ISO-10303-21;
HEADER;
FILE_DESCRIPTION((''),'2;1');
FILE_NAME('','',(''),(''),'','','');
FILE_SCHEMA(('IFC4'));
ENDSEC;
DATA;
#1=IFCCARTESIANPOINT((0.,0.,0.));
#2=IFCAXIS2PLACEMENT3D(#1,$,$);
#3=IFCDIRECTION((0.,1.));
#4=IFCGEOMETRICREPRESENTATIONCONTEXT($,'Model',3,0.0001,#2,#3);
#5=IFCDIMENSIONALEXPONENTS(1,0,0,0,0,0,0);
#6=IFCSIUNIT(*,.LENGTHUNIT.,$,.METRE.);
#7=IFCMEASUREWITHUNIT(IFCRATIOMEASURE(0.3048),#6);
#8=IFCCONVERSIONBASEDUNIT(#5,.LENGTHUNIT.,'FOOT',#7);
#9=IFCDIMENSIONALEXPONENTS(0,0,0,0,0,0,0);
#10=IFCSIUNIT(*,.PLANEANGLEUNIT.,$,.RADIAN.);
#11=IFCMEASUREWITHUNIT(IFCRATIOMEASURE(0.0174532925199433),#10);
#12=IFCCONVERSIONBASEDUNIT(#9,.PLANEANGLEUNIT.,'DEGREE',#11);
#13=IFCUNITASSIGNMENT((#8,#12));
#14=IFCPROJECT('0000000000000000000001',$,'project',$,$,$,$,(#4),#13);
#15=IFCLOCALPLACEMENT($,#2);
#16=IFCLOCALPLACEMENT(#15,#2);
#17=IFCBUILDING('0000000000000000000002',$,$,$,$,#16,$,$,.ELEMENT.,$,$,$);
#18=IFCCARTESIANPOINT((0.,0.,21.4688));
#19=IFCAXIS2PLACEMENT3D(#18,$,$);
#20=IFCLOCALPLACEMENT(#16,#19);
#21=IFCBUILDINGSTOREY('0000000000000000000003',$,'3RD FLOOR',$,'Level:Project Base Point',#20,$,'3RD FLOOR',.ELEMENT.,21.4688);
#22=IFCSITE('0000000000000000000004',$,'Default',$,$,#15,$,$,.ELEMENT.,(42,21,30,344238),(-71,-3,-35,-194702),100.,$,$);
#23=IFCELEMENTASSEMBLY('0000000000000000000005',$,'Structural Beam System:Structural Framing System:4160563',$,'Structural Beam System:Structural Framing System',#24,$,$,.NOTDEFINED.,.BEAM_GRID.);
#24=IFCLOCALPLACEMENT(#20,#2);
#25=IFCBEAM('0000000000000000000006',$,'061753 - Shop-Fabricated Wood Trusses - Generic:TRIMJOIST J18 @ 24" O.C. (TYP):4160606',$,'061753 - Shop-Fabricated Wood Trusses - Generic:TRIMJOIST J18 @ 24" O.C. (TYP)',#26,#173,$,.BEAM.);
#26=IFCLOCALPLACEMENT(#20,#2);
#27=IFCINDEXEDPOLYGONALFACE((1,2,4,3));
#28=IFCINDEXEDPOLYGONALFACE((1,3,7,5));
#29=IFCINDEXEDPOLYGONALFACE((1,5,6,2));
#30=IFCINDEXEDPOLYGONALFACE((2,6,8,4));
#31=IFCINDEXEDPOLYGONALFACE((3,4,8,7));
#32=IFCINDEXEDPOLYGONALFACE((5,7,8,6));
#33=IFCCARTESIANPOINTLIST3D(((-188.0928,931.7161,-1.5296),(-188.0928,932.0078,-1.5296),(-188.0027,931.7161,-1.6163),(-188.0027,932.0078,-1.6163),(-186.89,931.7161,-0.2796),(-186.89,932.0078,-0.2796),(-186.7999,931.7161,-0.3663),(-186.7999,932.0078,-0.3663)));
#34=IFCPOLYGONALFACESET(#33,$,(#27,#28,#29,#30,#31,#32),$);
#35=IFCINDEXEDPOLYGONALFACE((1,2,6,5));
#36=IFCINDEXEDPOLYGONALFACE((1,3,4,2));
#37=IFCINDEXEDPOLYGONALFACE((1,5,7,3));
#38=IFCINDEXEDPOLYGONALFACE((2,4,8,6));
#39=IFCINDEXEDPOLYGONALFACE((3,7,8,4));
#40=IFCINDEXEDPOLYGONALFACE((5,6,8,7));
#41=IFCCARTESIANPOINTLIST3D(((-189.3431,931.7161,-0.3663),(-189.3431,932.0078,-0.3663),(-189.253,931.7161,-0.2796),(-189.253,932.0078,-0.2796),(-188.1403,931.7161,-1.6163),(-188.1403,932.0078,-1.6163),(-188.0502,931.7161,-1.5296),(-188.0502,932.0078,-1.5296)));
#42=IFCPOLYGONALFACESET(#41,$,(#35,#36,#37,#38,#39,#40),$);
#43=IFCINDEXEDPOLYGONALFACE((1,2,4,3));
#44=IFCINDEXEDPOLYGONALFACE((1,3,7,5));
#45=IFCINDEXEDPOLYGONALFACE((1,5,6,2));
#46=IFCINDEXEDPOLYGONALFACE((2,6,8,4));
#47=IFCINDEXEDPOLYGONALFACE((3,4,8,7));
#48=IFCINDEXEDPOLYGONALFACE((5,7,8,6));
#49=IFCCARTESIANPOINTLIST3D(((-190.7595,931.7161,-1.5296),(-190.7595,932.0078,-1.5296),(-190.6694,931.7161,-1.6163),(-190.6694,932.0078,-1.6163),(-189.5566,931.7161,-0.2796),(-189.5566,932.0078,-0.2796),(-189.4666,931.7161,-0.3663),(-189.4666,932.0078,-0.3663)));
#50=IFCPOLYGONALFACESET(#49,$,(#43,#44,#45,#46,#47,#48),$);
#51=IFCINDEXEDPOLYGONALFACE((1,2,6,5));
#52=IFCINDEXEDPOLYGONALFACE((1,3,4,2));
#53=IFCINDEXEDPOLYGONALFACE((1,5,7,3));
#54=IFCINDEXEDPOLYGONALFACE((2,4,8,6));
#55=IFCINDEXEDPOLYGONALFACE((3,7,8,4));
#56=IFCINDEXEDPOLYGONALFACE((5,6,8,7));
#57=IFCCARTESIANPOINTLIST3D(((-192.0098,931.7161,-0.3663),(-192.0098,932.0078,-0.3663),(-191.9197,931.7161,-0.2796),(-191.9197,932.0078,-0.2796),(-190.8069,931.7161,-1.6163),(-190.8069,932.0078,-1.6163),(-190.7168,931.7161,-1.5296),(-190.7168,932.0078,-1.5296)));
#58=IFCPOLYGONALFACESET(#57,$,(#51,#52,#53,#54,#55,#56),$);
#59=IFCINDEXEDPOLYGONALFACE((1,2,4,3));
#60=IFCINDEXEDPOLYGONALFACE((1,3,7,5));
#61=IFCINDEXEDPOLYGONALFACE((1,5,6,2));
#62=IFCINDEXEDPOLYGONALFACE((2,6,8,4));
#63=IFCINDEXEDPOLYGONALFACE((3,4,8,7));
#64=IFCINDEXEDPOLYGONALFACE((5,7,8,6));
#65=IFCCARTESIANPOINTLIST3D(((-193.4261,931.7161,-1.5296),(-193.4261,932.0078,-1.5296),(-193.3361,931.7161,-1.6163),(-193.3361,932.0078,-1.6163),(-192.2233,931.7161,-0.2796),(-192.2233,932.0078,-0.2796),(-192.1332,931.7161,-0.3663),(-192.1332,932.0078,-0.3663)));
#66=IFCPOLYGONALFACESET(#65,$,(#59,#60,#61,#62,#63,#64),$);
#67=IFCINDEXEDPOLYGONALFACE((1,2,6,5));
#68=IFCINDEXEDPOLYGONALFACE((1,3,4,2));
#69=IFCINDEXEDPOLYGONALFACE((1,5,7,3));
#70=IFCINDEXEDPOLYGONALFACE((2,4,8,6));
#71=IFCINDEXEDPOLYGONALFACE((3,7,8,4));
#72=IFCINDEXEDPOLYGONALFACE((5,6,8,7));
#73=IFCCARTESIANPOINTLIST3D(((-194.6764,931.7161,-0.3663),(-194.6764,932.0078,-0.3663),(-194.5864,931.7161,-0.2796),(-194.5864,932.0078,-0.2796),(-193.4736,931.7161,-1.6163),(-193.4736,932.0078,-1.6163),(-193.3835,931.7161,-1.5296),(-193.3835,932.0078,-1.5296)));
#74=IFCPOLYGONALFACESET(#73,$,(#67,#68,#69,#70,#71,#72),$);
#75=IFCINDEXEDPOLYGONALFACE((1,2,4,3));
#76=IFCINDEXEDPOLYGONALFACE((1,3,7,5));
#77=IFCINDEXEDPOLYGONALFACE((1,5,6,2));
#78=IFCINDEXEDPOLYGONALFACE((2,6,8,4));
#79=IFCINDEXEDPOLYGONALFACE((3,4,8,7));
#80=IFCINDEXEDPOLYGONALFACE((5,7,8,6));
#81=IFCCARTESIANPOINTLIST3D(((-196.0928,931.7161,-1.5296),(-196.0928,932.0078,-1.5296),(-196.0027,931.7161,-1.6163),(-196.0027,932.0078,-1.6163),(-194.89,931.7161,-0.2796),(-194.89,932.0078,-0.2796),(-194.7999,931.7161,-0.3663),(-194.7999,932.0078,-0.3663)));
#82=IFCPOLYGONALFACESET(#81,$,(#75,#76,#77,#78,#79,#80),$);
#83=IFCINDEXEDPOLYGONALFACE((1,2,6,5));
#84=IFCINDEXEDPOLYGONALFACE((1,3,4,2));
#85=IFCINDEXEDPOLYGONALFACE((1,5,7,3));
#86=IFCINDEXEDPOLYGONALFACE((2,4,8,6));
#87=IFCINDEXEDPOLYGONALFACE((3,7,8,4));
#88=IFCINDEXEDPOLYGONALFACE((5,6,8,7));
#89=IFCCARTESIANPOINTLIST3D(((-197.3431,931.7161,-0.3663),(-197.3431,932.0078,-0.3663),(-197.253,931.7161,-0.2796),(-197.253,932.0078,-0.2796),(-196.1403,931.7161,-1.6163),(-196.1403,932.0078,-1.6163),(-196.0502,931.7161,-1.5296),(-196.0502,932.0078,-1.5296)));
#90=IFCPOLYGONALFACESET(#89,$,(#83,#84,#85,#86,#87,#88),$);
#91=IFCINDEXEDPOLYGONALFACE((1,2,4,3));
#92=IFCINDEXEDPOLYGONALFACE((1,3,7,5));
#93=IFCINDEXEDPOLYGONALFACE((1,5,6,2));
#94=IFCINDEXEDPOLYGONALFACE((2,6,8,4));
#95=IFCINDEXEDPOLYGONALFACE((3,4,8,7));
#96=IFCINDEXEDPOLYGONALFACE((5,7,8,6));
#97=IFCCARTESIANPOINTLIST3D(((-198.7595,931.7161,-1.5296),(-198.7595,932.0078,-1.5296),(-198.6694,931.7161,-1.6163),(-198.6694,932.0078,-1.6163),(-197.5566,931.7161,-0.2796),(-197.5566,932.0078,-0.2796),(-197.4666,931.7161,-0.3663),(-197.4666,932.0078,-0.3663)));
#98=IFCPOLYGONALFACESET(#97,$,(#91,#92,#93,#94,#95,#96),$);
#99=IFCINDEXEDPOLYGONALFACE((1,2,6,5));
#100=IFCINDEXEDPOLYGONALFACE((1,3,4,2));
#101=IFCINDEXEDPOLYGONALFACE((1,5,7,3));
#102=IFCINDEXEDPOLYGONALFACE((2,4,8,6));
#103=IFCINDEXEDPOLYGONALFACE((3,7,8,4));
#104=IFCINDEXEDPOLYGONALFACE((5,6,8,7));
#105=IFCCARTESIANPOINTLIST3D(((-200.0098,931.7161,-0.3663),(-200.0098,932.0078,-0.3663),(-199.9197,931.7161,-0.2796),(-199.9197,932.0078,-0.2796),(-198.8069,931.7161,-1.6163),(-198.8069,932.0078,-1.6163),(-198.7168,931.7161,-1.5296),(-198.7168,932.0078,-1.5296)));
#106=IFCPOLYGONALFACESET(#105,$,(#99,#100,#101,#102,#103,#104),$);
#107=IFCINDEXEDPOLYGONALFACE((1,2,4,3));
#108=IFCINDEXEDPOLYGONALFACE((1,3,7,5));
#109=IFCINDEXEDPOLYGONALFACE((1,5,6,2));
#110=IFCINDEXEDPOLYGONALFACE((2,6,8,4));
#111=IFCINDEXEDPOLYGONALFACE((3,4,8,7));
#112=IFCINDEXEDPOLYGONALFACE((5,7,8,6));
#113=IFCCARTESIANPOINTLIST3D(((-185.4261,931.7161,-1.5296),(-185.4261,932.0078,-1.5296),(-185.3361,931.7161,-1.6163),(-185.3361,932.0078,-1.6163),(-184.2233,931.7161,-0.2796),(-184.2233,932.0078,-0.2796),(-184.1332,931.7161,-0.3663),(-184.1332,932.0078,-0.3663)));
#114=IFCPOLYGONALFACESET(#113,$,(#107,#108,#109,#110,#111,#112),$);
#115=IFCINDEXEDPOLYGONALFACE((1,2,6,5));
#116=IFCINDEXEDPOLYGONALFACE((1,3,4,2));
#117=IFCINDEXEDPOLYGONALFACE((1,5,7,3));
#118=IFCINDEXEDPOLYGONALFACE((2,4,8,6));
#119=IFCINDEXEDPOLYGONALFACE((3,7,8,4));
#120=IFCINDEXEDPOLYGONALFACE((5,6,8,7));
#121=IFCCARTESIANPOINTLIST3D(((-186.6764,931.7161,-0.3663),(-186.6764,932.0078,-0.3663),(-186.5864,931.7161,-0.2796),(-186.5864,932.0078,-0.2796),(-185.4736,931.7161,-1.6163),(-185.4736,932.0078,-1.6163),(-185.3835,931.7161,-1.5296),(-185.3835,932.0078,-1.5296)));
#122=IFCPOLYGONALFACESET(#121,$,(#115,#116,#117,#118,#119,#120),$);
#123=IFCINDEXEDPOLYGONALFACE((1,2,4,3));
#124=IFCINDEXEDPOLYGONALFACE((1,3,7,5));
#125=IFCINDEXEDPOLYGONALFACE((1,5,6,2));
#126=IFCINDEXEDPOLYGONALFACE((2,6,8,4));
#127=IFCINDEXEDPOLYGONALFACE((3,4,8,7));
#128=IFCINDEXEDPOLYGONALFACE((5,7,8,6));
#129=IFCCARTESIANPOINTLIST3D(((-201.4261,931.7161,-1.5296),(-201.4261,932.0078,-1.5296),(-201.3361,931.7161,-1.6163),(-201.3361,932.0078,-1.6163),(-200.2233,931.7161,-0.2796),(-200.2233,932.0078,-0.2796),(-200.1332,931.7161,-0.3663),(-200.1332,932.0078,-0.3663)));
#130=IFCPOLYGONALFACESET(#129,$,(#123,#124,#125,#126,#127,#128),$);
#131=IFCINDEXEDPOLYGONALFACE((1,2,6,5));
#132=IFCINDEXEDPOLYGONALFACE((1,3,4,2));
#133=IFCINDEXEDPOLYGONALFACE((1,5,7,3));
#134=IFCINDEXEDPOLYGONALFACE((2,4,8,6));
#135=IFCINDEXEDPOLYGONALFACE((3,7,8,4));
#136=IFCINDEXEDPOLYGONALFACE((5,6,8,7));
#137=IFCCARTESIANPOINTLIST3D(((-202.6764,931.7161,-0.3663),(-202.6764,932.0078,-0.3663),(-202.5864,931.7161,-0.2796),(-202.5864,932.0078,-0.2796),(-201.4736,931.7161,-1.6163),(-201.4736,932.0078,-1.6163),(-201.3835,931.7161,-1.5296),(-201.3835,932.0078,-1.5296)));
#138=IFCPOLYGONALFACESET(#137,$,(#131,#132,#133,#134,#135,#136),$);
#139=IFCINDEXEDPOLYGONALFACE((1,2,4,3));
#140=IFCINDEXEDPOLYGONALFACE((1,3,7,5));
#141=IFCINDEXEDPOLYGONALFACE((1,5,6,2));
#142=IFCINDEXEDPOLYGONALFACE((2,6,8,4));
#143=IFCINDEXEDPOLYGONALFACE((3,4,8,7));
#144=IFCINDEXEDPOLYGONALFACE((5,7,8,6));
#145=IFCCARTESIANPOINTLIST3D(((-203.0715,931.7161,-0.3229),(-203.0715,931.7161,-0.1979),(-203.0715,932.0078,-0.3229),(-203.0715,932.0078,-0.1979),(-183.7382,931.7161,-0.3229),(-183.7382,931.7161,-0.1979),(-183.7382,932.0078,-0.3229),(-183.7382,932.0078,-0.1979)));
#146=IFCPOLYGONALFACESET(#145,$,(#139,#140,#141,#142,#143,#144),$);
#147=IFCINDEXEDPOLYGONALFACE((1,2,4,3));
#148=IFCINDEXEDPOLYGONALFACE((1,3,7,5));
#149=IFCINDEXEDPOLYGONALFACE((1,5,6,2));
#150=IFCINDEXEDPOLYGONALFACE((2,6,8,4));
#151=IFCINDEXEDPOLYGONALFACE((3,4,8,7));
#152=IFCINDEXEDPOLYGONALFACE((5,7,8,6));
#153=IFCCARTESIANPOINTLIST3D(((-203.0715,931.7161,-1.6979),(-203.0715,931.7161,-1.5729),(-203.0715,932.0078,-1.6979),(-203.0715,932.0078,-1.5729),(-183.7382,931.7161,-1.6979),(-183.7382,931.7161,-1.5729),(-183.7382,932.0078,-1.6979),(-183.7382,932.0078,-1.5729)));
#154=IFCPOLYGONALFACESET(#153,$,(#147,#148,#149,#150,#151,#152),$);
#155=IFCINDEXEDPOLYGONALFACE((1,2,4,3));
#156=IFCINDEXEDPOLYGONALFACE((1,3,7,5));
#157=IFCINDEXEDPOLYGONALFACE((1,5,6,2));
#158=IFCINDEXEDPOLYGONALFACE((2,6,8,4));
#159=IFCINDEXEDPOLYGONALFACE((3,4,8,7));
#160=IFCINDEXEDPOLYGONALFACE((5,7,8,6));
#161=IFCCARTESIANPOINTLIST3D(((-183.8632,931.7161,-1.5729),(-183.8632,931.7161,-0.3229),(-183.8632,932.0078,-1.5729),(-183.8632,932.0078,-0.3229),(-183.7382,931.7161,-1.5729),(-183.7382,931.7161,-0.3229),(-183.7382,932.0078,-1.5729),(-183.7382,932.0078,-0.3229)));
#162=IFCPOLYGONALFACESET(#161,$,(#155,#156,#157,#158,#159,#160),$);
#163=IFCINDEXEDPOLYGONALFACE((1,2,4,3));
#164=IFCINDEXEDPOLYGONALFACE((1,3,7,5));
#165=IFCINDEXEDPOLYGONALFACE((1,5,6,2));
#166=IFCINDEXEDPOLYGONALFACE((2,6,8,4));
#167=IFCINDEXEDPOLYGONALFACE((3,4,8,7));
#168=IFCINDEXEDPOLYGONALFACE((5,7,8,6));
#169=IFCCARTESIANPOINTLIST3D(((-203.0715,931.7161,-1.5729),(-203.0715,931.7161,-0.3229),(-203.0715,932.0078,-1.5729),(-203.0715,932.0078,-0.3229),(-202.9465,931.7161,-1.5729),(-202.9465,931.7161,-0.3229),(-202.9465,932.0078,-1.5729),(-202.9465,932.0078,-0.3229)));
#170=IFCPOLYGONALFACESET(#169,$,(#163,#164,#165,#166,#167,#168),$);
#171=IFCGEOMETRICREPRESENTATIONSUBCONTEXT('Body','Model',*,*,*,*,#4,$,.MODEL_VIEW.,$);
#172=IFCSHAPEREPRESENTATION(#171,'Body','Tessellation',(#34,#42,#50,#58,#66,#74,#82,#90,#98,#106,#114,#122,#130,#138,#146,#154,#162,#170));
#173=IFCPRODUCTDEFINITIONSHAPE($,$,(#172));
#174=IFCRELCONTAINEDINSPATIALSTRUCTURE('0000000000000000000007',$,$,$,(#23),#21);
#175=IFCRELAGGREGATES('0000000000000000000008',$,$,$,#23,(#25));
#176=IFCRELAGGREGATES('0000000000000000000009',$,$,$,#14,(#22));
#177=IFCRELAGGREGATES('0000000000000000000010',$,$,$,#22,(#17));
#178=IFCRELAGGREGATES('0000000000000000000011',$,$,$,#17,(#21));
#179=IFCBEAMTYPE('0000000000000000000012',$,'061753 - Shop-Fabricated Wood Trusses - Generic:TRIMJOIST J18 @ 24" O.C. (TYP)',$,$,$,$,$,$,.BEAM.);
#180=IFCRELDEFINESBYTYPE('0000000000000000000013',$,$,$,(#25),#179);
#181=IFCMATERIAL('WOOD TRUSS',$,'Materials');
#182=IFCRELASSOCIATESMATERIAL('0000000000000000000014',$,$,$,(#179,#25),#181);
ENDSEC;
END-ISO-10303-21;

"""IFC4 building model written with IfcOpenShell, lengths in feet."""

from ifc_helpers import new_model, entity, si_unit, converted_unit, direction, frame, frame_2d, origin, origin_2d_with_axis, place, context, subcontext, project, spatial, rectangle, extrude, source, transform, mapped, material, material_profile, profile_set, profile_usage, type_object, type_shapes, element, aggregate, save


model = new_model("IFC4")

# Units and contexts
model_context = context("Model", 3, precision=0.0001, world=origin(), true_north=direction((0.0, 1.0)))
body_context = subcontext(model_context, "Body", "Model", "MODEL_VIEW")
ifc_project = project(units=[converted_unit("LENGTHUNIT", "FOOT", entity("IfcRatioMeasure", 0.3048), si_unit("LENGTHUNIT", "METRE"), dimensions=[1, 0, 0, 0, 0, 0, 0]), converted_unit("PLANEANGLEUNIT", "DEGREE", entity("IfcRatioMeasure", 0.0174532925199433), si_unit("PLANEANGLEUNIT", "RADIAN"), dimensions=[0, 0, 0, 0, 0, 0, 0])], contexts=[model_context])

# Site, building, storey
site_placement = place(None, origin())
site = spatial("IfcSite", under=ifc_project, at=site_placement, Name="Default", CompositionType="ELEMENT", RefLatitude=(42, 21, 30, 344238), RefLongitude=(-71, -3, -35, -194702), RefElevation=100.0)
building_placement = place(site_placement, origin())
building = spatial("IfcBuilding", under=site, at=building_placement, CompositionType="ELEMENT")
storey_placement = place(building_placement, frame((0.0, 0.0, 21.4688)))
storey = spatial("IfcBuildingStorey", under=building, at=storey_placement, Name="3RD FLOOR", ObjectType="Level:Project Base Point", LongName="3RD FLOOR", CompositionType="ELEMENT", Elevation=21.4688)

# Element assembly, beam
ifc_material = material(Name="WOOD TRUSS", Category="Materials")
ifc_material_profile_1 = material_profile(ifc_material, rectangle(XDim=1.7347, YDim=0.125, at=frame_2d((0.0, 0.0), x_axis=(1.0, 0.0))), Name="TRIMJOIST J18 @ 24\" O.C. (TYP)")
ifc_material_profile_2 = material_profile(ifc_material, rectangle(XDim=1.7347, YDim=0.125, at=frame_2d((0.0, 0.0), x_axis=(1.0, 0.0))), Name="TRIMJOIST J18 @ 24\" O.C. (TYP)")
ifc_material_profile_3 = material_profile(ifc_material, rectangle(XDim=1.7347, YDim=0.125, at=frame_2d((0.0, 0.0), x_axis=(1.0, 0.0))), Name="TRIMJOIST J18 @ 24\" O.C. (TYP)")
ifc_material_profile_4 = material_profile(ifc_material, rectangle(XDim=1.7347, YDim=0.125, at=frame_2d((0.0, 0.0), x_axis=(1.0, 0.0))), Name="TRIMJOIST J18 @ 24\" O.C. (TYP)")
ifc_material_profile_5 = material_profile(ifc_material, rectangle(XDim=1.7347, YDim=0.125, at=frame_2d((0.0, 0.0), x_axis=(1.0, 0.0))), Name="TRIMJOIST J18 @ 24\" O.C. (TYP)")
ifc_material_profile_6 = material_profile(ifc_material, rectangle(XDim=1.7347, YDim=0.125, at=frame_2d((0.0, 0.0), x_axis=(1.0, 0.0))), Name="TRIMJOIST J18 @ 24\" O.C. (TYP)")
ifc_material_profile_7 = material_profile(ifc_material, rectangle(XDim=1.7347, YDim=0.125, at=frame_2d((0.0, 0.0), x_axis=(1.0, 0.0))), Name="TRIMJOIST J18 @ 24\" O.C. (TYP)")
ifc_material_profile_8 = material_profile(ifc_material, rectangle(XDim=1.7347, YDim=0.125, at=frame_2d((0.0, 0.0), x_axis=(1.0, 0.0))), Name="TRIMJOIST J18 @ 24\" O.C. (TYP)")
ifc_material_profile_9 = material_profile(ifc_material, rectangle(XDim=1.7347, YDim=0.125, at=frame_2d((0.0, 0.0), x_axis=(1.0, 0.0))), Name="TRIMJOIST J18 @ 24\" O.C. (TYP)")
ifc_material_profile_10 = material_profile(ifc_material, rectangle(XDim=1.7347, YDim=0.125, at=origin_2d_with_axis()), Name="TRIMJOIST J18 @ 24\" O.C. (TYP)")
ifc_material_profile_11 = material_profile(ifc_material, rectangle(XDim=0.125, YDim=0.2917, at=origin_2d_with_axis()), Name="TRIMJOIST J18 @ 24\" O.C. (TYP)")
ifc_material_profile_12 = material_profile(ifc_material, rectangle(XDim=0.125, YDim=0.2917, at=origin_2d_with_axis()), Name="TRIMJOIST J18 @ 24\" O.C. (TYP)")
ifc_material_profile_13 = material_profile(ifc_material, rectangle(XDim=1.25, YDim=0.2917, at=origin_2d_with_axis()), Name="TRIMJOIST J18 @ 24\" O.C. (TYP)")
ifc_material_profile_14 = material_profile(ifc_material, rectangle(XDim=1.25, YDim=0.2917, at=origin_2d_with_axis()), Name="TRIMJOIST J18 @ 24\" O.C. (TYP)")
ifc_profile_set = profile_set([ifc_material_profile_1, ifc_material_profile_2, ifc_material_profile_3, ifc_material_profile_4, ifc_material_profile_5, ifc_material_profile_6, ifc_material_profile_7, ifc_material_profile_8, ifc_material_profile_9, ifc_material_profile_10, ifc_material_profile_11, ifc_material_profile_12, ifc_material_profile_13, ifc_material_profile_14], Name="TRIMJOIST J18 @ 24\" O.C. (TYP)")
beam_type_1 = type_object("IfcBeamType", Name="061753 - Shop-Fabricated Wood Trusses - Generic:TRIMJOIST J18 @ 24\" O.C. (TYP)", PredefinedType="BEAM", material=ifc_profile_set)
shared_shape_1 = source(origin(), body_context, "Body", "SweptSolid", [
    extrude(rectangle(XDim=1.7347, YDim=0.125, at=frame_2d((0.0, 0.0), x_axis=(1.0, 0.0))), frame((5.9585, -0.1458, 0.0), z_axis=(0.0, 1.0, 0.0), x_axis=(0.693383, 0.0, 0.720569)), (0.0, 0.0, 1.0), 0.2917),
    extrude(rectangle(XDim=1.7347, YDim=0.125, at=origin_2d_with_axis()), frame((4.7082, -0.1458, 0.0), z_axis=(0.0, 1.0, 0.0), x_axis=(0.693383, 0.0, -0.720569)), (0.0, 0.0, 1.0), 0.2917),
    extrude(rectangle(XDim=1.7347, YDim=0.125, at=frame_2d((0.0, 0.0), x_axis=(1.0, 0.0))), frame((3.2918, -0.1458, 0.0), z_axis=(0.0, 1.0, 0.0), x_axis=(0.693383, 0.0, 0.720569)), (0.0, 0.0, 1.0), 0.2917),
    extrude(rectangle(XDim=1.7347, YDim=0.125, at=frame_2d((0.0, 0.0), x_axis=(1.0, 0.0))), frame((2.0415, -0.1458, 0.0), z_axis=(0.0, 1.0, 0.0), x_axis=(0.693383, 0.0, -0.720569)), (0.0, 0.0, 1.0), 0.2917),
    extrude(rectangle(XDim=1.7347, YDim=0.125, at=frame_2d((0.0, 0.0), x_axis=(1.0, 0.0))), frame((0.6251, -0.1458, 0.0), z_axis=(0.0, 1.0, 0.0), x_axis=(0.693383, 0.0, 0.720569)), (0.0, 0.0, 1.0), 0.2917),
    extrude(rectangle(XDim=1.7347, YDim=0.125, at=frame_2d((0.0, 0.0), x_axis=(1.0, 0.0))), frame((-0.6251, -0.1458, 0.0), z_axis=(0.0, 1.0, 0.0), x_axis=(0.693383, 0.0, -0.720569)), (0.0, 0.0, 1.0), 0.2917),
    extrude(rectangle(XDim=1.7347, YDim=0.125, at=frame_2d((0.0, 0.0), x_axis=(1.0, 0.0))), frame((-2.0415, -0.1458, 0.0), z_axis=(0.0, 1.0, 0.0), x_axis=(0.693383, 0.0, 0.720569)), (0.0, 0.0, 1.0), 0.2917),
    extrude(rectangle(XDim=1.7347, YDim=0.125, at=origin_2d_with_axis()), frame((-3.2918, -0.1458, 0.0), z_axis=(0.0, 1.0, 0.0), x_axis=(0.693383, 0.0, -0.720569)), (0.0, 0.0, 1.0), 0.2917),
    extrude(rectangle(XDim=1.7347, YDim=0.125, at=frame_2d((0.0, 0.0), x_axis=(1.0, 0.0))), frame((-4.7082, -0.1458, 0.0), z_axis=(0.0, 1.0, 0.0), x_axis=(0.693383, 0.0, 0.720569)), (0.0, 0.0, 1.0), 0.2917),
    extrude(rectangle(XDim=1.7347, YDim=0.125, at=frame_2d((0.0, 0.0), x_axis=(1.0, 0.0))), frame((-5.9585, -0.1458, 0.0), z_axis=(0.0, 1.0, 0.0), x_axis=(0.693383, 0.0, -0.720569)), (0.0, 0.0, 1.0), 0.2917),
    extrude(rectangle(XDim=1.7347, YDim=0.125, at=frame_2d((0.0, 0.0), x_axis=(1.0, 0.0))), frame((8.6251, -0.1458, 0.0), z_axis=(0.0, 1.0, 0.0), x_axis=(0.693383, 0.0, 0.720569)), (0.0, 0.0, 1.0), 0.2917),
    extrude(rectangle(XDim=1.7347, YDim=0.125, at=origin_2d_with_axis()), frame((7.3749, -0.1458, 0.0), z_axis=(0.0, 1.0, 0.0), x_axis=(0.693383, 0.0, -0.720569)), (0.0, 0.0, 1.0), 0.2917),
    extrude(rectangle(XDim=1.7347, YDim=0.125, at=frame_2d((0.0, 0.0), x_axis=(1.0, 0.0))), frame((-7.3749, -0.1458, 0.0), z_axis=(0.0, 1.0, 0.0), x_axis=(0.693383, 0.0, 0.720569)), (0.0, 0.0, 1.0), 0.2917),
    extrude(rectangle(XDim=1.7347, YDim=0.125, at=origin_2d_with_axis()), frame((-8.6251, -0.1458, 0.0), z_axis=(0.0, 1.0, 0.0), x_axis=(0.693383, 0.0, -0.720569)), (0.0, 0.0, 1.0), 0.2917),
    extrude(rectangle(XDim=0.125, YDim=0.2917, at=origin_2d_with_axis()), frame((-9.6667, 0.0, 0.6875), z_axis=(1.0, 0.0, 0.0), x_axis=(0.0, 0.0, -1.0)), (0.0, 0.0, 1.0), 19.3333),
    extrude(rectangle(XDim=0.125, YDim=0.2917, at=origin_2d_with_axis()), frame((-9.6667, 0.0, -0.6875), z_axis=(1.0, 0.0, 0.0), x_axis=(0.0, 0.0, -1.0)), (0.0, 0.0, 1.0), 19.3333),
    extrude(rectangle(XDim=1.25, YDim=0.2917, at=origin_2d_with_axis()), frame((9.5417, 0.0, 0.0), z_axis=(1.0, 0.0, 0.0), x_axis=(0.0, 0.0, -1.0)), (0.0, 0.0, 1.0), 0.125),
    extrude(rectangle(XDim=1.25, YDim=0.2917, at=origin_2d_with_axis()), frame((-9.6667, 0.0, 0.0), z_axis=(1.0, 0.0, 0.0), x_axis=(0.0, 0.0, -1.0)), (0.0, 0.0, 1.0), 0.125),
])
type_shapes(beam_type_1, [shared_shape_1])
assembly_1_placement = place(storey_placement, origin())
assembly_1 = element("IfcElementAssembly", 1, at=assembly_1_placement, inside=storey, Name="Structural Beam System:Structural Framing System:4160563", ObjectType="Structural Beam System:Structural Framing System", AssemblyPlace="NOTDEFINED", PredefinedType="BEAM_GRID")
ifc_profile_usage_1 = profile_usage(ifc_profile_set, cardinal=8)
beam_1_placement = place(assembly_1_placement, frame((-193.4048, 931.8619, -0.9479)))
beam_1 = element("IfcBeam", 2, at=beam_1_placement, type_object=beam_type_1, material=ifc_profile_usage_1, Name="061753 - Shop-Fabricated Wood Trusses - Generic:TRIMJOIST J18 @ 24\" O.C. (TYP):4160606", ObjectType="061753 - Shop-Fabricated Wood Trusses - Generic:TRIMJOIST J18 @ 24\" O.C. (TYP)", PredefinedType="BEAM", context=body_context, shape_type="MappedRepresentation", body=[
    mapped(shared_shape_1, transform((0.0, 0.0, 0.0), scale=1.0)),
])
aggregate(assembly_1, [beam_1])

save(model, "model.ifc")
